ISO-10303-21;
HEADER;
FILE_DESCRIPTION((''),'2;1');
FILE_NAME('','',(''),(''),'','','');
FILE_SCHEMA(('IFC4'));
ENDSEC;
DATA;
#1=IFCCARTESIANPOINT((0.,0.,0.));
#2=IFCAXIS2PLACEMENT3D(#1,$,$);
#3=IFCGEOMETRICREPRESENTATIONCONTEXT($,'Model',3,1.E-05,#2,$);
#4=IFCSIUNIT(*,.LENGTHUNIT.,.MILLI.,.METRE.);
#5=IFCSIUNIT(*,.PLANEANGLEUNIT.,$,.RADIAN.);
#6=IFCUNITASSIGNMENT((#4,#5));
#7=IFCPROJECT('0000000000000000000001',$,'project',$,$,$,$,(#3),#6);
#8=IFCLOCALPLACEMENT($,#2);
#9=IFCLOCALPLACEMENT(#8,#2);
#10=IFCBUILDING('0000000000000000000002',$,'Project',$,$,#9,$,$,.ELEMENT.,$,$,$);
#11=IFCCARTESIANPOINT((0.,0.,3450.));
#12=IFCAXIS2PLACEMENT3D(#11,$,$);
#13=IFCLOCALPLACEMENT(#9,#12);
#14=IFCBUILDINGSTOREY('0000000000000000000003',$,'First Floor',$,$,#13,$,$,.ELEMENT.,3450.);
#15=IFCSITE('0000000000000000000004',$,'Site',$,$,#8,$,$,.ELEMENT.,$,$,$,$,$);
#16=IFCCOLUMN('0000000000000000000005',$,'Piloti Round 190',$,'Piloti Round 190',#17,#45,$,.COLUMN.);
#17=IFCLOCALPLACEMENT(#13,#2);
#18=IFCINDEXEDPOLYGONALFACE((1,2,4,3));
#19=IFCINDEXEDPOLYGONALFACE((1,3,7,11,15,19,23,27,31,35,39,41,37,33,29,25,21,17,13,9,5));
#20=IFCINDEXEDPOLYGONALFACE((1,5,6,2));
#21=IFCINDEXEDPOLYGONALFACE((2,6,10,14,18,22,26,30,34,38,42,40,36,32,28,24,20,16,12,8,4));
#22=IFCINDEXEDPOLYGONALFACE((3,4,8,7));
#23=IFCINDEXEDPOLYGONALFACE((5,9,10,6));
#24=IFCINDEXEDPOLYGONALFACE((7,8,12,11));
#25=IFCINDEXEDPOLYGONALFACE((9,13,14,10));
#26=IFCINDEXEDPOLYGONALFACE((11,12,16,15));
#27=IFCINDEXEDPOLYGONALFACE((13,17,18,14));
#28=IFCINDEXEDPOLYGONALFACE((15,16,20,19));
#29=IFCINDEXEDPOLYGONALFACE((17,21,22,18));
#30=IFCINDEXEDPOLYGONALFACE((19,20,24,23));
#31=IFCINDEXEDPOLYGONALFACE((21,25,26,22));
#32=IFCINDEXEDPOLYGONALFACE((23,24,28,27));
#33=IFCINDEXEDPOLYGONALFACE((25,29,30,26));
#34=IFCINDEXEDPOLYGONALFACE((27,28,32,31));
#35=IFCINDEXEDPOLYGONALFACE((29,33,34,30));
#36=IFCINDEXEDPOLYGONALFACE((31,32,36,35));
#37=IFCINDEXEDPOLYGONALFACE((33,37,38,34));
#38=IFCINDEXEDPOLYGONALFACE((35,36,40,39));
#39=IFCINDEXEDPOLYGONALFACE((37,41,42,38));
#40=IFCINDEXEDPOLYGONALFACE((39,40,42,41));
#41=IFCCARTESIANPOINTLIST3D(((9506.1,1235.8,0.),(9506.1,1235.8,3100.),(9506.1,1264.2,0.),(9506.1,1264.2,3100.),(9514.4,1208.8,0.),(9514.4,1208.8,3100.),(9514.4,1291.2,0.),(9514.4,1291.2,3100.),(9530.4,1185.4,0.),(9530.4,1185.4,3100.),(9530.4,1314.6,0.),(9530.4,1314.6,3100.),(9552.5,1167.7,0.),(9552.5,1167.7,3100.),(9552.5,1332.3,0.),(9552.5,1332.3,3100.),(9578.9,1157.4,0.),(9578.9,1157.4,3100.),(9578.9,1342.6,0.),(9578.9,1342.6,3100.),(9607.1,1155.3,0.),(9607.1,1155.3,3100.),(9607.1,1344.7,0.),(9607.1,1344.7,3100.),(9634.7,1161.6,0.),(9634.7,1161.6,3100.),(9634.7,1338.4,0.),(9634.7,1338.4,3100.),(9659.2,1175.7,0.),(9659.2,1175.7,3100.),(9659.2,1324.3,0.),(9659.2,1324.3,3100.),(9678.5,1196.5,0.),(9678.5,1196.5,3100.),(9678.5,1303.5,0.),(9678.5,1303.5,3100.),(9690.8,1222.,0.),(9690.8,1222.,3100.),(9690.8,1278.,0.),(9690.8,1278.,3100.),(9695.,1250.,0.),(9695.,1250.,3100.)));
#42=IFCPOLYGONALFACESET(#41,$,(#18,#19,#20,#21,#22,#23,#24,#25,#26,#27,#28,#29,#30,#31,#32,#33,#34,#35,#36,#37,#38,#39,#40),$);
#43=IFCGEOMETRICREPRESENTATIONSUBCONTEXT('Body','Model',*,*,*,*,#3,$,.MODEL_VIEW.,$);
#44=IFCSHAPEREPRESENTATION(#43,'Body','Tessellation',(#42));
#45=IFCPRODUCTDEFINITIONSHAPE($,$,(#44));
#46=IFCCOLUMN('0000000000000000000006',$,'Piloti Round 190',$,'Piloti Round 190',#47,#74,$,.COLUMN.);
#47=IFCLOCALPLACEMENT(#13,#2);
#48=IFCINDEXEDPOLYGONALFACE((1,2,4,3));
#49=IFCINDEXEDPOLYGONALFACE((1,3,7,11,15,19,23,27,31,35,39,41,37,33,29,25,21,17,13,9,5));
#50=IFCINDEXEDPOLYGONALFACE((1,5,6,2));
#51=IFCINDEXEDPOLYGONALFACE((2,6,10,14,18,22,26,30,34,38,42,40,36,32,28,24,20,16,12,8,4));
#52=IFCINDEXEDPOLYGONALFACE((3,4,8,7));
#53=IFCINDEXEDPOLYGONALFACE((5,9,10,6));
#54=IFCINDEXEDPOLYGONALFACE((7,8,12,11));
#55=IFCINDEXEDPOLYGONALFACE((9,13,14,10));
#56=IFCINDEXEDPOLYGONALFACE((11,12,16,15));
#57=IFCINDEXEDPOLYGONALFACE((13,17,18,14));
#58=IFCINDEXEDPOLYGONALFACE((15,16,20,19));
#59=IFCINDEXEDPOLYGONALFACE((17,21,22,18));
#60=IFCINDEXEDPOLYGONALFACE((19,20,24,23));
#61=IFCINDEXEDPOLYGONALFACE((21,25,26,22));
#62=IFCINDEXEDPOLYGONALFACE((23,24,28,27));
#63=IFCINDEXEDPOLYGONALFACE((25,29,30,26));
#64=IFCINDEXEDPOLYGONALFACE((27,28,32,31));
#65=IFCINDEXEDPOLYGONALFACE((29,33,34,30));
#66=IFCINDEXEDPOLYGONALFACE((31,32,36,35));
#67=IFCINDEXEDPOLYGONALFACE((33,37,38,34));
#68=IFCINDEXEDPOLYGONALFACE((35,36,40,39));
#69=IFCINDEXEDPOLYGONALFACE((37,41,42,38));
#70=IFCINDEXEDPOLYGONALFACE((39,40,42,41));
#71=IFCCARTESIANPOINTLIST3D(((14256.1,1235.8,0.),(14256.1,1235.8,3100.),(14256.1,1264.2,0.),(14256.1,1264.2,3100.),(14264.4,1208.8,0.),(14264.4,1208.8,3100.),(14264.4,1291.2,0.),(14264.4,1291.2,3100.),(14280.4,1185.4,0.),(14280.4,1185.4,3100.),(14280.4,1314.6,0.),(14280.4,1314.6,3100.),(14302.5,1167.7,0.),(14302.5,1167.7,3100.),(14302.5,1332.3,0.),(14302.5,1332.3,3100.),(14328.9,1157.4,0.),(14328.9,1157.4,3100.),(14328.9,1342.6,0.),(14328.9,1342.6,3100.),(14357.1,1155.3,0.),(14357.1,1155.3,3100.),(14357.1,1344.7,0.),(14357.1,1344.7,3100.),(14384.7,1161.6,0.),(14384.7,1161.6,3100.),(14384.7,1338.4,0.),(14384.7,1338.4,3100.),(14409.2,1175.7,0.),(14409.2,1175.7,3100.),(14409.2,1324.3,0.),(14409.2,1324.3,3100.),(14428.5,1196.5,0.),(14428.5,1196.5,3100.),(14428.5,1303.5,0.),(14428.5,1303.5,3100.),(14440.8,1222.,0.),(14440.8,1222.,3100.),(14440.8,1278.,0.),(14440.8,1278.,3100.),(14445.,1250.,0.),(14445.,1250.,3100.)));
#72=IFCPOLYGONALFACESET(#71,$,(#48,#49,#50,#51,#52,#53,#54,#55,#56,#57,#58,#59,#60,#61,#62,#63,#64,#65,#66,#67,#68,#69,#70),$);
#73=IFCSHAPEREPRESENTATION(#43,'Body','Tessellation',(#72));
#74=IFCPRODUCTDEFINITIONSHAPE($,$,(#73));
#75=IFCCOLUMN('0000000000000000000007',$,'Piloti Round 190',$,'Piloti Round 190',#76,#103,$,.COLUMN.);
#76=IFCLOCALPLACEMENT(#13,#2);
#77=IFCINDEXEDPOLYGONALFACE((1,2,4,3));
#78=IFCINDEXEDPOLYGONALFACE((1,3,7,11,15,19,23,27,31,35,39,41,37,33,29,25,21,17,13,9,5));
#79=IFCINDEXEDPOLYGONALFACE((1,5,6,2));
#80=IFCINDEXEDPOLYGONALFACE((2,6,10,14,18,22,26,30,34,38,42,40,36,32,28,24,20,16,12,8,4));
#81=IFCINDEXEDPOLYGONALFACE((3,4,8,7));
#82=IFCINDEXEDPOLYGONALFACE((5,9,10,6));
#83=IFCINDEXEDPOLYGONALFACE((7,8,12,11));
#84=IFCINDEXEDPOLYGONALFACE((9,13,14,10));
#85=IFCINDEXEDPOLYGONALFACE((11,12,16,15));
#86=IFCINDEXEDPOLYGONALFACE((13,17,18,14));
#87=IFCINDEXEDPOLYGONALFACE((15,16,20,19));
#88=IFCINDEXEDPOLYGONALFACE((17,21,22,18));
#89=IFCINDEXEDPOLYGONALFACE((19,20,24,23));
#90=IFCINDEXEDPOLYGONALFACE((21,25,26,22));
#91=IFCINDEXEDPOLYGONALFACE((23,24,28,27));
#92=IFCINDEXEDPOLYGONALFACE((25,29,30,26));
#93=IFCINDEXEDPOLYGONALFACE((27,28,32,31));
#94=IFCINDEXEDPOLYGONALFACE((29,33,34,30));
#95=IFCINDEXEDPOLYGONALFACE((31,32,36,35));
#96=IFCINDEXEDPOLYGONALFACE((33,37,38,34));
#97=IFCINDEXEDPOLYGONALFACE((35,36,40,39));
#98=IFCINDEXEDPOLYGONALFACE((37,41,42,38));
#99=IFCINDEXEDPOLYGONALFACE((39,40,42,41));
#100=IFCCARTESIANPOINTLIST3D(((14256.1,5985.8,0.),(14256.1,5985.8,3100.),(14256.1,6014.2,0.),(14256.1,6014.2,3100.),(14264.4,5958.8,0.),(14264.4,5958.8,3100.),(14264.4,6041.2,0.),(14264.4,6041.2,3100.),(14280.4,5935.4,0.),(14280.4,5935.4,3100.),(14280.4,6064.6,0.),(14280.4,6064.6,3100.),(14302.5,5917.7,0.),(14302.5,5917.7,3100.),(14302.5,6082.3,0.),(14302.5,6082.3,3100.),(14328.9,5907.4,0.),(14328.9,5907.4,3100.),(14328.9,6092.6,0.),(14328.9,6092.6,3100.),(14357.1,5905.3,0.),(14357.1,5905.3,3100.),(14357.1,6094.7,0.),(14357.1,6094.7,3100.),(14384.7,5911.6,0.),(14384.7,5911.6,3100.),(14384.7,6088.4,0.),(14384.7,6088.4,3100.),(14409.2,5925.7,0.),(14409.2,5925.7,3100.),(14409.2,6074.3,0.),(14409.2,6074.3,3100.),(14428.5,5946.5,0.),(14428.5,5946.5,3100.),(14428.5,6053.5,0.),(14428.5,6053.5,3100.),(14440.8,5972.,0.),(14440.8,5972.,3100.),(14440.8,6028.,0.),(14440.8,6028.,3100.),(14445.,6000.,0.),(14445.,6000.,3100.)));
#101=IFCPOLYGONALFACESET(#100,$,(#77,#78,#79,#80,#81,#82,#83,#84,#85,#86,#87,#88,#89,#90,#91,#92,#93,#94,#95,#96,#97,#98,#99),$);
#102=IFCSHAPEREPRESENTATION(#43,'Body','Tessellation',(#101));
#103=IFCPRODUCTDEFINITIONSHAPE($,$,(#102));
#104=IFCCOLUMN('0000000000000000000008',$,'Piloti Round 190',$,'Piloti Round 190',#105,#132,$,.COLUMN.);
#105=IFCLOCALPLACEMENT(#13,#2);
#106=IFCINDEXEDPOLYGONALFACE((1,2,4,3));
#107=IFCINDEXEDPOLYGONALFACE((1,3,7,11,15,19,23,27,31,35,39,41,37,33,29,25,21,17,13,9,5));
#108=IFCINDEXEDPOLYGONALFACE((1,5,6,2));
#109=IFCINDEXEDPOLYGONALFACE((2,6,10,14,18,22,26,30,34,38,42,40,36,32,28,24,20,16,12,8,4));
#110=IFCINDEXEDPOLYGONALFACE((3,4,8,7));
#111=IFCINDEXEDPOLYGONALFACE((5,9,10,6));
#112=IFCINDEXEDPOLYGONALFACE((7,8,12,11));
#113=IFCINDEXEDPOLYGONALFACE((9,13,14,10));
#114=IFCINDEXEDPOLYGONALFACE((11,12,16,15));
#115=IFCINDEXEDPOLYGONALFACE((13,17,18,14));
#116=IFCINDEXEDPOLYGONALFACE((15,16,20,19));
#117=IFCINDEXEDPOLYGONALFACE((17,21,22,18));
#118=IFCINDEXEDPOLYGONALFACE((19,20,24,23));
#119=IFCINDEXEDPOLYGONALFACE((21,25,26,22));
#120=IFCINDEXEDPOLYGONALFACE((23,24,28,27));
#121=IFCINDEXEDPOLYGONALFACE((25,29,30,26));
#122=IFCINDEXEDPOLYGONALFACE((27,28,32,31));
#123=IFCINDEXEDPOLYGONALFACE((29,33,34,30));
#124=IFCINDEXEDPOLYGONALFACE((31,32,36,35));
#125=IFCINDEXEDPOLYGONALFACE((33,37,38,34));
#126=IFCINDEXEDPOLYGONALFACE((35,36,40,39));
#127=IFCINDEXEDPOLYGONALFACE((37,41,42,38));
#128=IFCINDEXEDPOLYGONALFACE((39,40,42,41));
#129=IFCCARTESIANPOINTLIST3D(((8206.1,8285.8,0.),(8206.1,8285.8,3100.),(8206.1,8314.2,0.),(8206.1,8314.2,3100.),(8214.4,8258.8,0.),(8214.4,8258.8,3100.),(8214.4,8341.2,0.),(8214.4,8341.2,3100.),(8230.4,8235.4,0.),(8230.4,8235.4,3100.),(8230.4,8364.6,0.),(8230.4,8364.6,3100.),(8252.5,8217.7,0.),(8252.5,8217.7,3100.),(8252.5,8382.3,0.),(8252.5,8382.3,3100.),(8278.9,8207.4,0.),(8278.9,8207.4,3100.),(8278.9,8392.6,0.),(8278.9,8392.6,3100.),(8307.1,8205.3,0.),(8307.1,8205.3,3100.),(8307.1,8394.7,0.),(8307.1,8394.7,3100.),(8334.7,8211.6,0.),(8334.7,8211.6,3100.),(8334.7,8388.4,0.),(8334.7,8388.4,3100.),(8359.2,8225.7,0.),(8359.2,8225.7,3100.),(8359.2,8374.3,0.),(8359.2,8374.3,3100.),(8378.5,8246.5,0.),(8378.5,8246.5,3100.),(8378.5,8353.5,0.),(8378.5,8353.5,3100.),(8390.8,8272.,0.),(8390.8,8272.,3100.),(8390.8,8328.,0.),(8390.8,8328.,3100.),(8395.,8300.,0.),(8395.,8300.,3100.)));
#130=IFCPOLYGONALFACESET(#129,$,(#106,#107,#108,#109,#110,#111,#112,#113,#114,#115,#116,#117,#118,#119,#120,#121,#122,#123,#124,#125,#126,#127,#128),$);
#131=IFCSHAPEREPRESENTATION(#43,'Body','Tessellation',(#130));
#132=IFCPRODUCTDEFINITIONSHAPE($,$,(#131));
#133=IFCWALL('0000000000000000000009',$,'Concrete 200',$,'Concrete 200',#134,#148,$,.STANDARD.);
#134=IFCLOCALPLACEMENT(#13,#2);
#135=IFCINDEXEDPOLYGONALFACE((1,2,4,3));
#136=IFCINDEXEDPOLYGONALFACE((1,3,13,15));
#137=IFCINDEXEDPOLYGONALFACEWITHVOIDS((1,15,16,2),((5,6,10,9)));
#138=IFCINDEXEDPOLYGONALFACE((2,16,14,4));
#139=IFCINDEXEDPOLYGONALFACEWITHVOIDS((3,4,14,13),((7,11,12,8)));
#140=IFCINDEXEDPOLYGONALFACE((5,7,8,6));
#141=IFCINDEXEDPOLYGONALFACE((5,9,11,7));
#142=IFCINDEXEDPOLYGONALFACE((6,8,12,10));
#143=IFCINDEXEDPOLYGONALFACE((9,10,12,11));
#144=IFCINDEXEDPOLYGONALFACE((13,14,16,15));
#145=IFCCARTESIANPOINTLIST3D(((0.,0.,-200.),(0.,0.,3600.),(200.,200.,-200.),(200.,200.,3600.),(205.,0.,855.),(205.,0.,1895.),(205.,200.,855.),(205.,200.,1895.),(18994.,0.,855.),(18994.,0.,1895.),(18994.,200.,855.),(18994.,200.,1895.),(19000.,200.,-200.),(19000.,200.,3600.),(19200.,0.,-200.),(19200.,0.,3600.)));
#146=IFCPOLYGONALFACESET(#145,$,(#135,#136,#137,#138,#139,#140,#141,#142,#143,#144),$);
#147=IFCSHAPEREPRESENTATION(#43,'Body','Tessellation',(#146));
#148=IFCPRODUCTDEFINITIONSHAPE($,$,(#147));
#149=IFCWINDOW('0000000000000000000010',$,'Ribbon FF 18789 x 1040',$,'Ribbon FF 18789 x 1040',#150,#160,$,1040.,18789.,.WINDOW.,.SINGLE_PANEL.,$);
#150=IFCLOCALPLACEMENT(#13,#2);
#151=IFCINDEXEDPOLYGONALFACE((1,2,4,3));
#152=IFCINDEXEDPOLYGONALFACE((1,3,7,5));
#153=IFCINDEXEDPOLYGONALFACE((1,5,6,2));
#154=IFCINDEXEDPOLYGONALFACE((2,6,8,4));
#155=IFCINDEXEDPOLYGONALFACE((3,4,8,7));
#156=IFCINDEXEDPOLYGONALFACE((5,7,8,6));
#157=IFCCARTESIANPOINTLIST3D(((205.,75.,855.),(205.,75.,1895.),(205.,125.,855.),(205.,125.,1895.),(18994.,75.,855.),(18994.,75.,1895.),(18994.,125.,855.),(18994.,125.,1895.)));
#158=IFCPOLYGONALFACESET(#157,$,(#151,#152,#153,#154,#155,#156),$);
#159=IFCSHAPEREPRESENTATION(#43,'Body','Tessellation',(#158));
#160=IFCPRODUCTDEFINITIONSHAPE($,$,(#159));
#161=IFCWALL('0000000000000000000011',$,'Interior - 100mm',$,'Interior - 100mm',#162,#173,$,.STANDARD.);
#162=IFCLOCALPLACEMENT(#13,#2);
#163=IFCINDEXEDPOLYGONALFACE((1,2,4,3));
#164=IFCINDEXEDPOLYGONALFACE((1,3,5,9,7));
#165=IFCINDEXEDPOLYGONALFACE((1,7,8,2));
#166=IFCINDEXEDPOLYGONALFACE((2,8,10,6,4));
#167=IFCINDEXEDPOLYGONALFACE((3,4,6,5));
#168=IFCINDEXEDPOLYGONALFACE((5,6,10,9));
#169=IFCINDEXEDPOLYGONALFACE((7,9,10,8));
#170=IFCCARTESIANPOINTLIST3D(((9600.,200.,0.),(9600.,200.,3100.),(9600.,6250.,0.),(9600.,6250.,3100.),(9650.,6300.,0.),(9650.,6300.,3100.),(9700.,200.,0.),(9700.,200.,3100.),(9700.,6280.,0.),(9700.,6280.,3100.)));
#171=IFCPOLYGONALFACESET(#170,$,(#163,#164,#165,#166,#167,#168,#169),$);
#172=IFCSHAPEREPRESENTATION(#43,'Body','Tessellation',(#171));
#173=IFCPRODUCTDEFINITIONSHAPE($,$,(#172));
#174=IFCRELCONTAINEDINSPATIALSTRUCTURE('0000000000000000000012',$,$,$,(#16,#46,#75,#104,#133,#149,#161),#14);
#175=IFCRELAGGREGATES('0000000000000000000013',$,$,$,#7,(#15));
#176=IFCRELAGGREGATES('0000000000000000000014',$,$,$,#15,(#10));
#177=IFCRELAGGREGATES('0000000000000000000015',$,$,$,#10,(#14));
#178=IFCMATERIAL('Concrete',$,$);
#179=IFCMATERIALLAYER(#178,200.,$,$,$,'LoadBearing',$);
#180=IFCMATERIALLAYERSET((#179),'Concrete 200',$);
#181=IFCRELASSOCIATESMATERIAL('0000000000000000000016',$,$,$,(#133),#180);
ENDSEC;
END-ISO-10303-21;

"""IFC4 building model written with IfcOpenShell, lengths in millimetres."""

from ifc_helpers import new_model, si_unit, frame, frame_2d, origin, origin_2d, place, context, subcontext, project, spatial, polyline, rectangle, circle, outline, extrude, material, layer, layer_set, layer_usage, element, fill, save


model = new_model("IFC4")

# Units and contexts
model_context = context("Model", 3, precision=1e-05, world=origin())
body_context = subcontext(model_context, "Body", "Model", "MODEL_VIEW")
ifc_project = project(units=[si_unit("LENGTHUNIT", "METRE", prefix="MILLI"), si_unit("PLANEANGLEUNIT", "RADIAN")], contexts=[model_context])

# Site, building, storey
site_placement = place(None, origin())
site = spatial("IfcSite", under=ifc_project, at=site_placement, Name="Site", CompositionType="ELEMENT")
building_placement = place(site_placement, origin())
building = spatial("IfcBuilding", under=site, at=building_placement, Name="Project", CompositionType="ELEMENT")
storey_placement = place(building_placement, frame((0.0, 0.0, 3450.0)))
storey = spatial("IfcBuildingStorey", under=building, at=storey_placement, Name="First Floor", CompositionType="ELEMENT", Elevation=3450.0)

# Columns
for number, where, z_axis, x_axis, name in (
    (1, (9600.0, 1250.0, 0.0), (0.0, 0.0, 1.0), (1.0, 0.0, 0.0), "Piloti Round 190"),
    (2, (14350.0, 1250.0, 0.0), (0.0, 0.0, 1.0), (1.0, 0.0, 0.0), "Piloti Round 190"),
    (3, (14350.0, 6000.0, 0.0), (0.0, 0.0, 1.0), (1.0, 0.0, 0.0), "Piloti Round 190"),
    (4, (8300.0, 8300.0, 0.0), (0.0, 0.0, 1.0), (1.0, 0.0, 0.0), "Piloti Round 190"),
):
    element("IfcColumn", number, at=place(storey_placement, frame(where, z_axis=z_axis, x_axis=x_axis)), inside=storey, Name=name, ObjectType="Piloti Round 190", PredefinedType="COLUMN", context=body_context, shape_type="SweptSolid", body=[
        extrude(circle(Radius=95.0, at=origin_2d()), origin(), (0.0, 0.0, 1.0), 3100.0),
    ])

# Wall, opening, window
ifc_material_1 = material(Name="Concrete")
ifc_layer_1 = layer(ifc_material_1, 200.0, Category="LoadBearing")
ifc_layer_set_1 = layer_set([ifc_layer_1], Name="Concrete 200")
ifc_layer_usage_1 = layer_usage(ifc_layer_set_1, "AXIS2", "NEGATIVE", 100.0)
wall_1_placement = place(storey_placement, frame((19100.0, 100.0, -200.0), z_axis=(0.0, 0.0, 1.0), x_axis=(-1.0, 0.0, 0.0)))
wall_1 = element("IfcWall", 5, at=wall_1_placement, inside=storey, material=ifc_layer_usage_1, Name="Concrete 200", ObjectType="Concrete 200", PredefinedType="STANDARD", context=body_context, shape_type="SweptSolid", body=[
    extrude(outline(polyline([(100.0, -100.0), (0.0, 0.0), (-100.0, 100.0), (19100.0, 100.0), (19000.0, 0.0), (18900.0, -100.0), (100.0, -100.0)])), origin(), (0.0, 0.0, 1.0), 3800.0),
])
opening_1_placement = place(wall_1_placement, frame((106.0, 0.0, 1055.0), z_axis=(0.0, 0.0, 1.0), x_axis=(1.0, 0.0, 0.0)))
opening_1 = element("IfcOpeningElement", 6, at=opening_1_placement, cuts=wall_1, PredefinedType="OPENING", context=body_context, shape_type="SweptSolid", body=[
    extrude(rectangle(XDim=18789.0, YDim=220.0, at=frame_2d((9394.5, 0.0))), origin(), (0.0, 0.0, 1.0), 1040.0),
])
window_placement = place(opening_1_placement, origin())
window = element("IfcWindow", 7, at=window_placement, inside=storey, Name="Ribbon FF 18789 x 1040", ObjectType="Ribbon FF 18789 x 1040", OverallHeight=1040.0, OverallWidth=18789.0, PartitioningType="SINGLE_PANEL", PredefinedType="WINDOW", context=body_context, shape_type="SweptSolid", body=[
    extrude(rectangle(XDim=18789.0, YDim=50.0, at=frame_2d((9394.5, 0.0))), origin(), (0.0, 0.0, 1.0), 1040.0),
])
fill(opening_1, window)

# Wall
wall_2_placement = place(storey_placement, frame((9650.0, 200.0, 0.0), z_axis=(0.0, 0.0, 1.0), x_axis=(0.0, 1.0, 0.0)))
element("IfcWall", 8, at=wall_2_placement, inside=storey, Name="Interior - 100mm", ObjectType="Interior - 100mm", PredefinedType="STANDARD", context=body_context, shape_type="SweptSolid", body=[
    extrude(outline(polyline([(0.0, -50.0), (0.0, 50.0), (6050.0, 50.0), (6100.0, 0.0), (6080.0, -50.0), (0.0, -50.0)])), origin(), (0.0, 0.0, 1.0), 3100.0),
])

save(model, "model.ifc")
